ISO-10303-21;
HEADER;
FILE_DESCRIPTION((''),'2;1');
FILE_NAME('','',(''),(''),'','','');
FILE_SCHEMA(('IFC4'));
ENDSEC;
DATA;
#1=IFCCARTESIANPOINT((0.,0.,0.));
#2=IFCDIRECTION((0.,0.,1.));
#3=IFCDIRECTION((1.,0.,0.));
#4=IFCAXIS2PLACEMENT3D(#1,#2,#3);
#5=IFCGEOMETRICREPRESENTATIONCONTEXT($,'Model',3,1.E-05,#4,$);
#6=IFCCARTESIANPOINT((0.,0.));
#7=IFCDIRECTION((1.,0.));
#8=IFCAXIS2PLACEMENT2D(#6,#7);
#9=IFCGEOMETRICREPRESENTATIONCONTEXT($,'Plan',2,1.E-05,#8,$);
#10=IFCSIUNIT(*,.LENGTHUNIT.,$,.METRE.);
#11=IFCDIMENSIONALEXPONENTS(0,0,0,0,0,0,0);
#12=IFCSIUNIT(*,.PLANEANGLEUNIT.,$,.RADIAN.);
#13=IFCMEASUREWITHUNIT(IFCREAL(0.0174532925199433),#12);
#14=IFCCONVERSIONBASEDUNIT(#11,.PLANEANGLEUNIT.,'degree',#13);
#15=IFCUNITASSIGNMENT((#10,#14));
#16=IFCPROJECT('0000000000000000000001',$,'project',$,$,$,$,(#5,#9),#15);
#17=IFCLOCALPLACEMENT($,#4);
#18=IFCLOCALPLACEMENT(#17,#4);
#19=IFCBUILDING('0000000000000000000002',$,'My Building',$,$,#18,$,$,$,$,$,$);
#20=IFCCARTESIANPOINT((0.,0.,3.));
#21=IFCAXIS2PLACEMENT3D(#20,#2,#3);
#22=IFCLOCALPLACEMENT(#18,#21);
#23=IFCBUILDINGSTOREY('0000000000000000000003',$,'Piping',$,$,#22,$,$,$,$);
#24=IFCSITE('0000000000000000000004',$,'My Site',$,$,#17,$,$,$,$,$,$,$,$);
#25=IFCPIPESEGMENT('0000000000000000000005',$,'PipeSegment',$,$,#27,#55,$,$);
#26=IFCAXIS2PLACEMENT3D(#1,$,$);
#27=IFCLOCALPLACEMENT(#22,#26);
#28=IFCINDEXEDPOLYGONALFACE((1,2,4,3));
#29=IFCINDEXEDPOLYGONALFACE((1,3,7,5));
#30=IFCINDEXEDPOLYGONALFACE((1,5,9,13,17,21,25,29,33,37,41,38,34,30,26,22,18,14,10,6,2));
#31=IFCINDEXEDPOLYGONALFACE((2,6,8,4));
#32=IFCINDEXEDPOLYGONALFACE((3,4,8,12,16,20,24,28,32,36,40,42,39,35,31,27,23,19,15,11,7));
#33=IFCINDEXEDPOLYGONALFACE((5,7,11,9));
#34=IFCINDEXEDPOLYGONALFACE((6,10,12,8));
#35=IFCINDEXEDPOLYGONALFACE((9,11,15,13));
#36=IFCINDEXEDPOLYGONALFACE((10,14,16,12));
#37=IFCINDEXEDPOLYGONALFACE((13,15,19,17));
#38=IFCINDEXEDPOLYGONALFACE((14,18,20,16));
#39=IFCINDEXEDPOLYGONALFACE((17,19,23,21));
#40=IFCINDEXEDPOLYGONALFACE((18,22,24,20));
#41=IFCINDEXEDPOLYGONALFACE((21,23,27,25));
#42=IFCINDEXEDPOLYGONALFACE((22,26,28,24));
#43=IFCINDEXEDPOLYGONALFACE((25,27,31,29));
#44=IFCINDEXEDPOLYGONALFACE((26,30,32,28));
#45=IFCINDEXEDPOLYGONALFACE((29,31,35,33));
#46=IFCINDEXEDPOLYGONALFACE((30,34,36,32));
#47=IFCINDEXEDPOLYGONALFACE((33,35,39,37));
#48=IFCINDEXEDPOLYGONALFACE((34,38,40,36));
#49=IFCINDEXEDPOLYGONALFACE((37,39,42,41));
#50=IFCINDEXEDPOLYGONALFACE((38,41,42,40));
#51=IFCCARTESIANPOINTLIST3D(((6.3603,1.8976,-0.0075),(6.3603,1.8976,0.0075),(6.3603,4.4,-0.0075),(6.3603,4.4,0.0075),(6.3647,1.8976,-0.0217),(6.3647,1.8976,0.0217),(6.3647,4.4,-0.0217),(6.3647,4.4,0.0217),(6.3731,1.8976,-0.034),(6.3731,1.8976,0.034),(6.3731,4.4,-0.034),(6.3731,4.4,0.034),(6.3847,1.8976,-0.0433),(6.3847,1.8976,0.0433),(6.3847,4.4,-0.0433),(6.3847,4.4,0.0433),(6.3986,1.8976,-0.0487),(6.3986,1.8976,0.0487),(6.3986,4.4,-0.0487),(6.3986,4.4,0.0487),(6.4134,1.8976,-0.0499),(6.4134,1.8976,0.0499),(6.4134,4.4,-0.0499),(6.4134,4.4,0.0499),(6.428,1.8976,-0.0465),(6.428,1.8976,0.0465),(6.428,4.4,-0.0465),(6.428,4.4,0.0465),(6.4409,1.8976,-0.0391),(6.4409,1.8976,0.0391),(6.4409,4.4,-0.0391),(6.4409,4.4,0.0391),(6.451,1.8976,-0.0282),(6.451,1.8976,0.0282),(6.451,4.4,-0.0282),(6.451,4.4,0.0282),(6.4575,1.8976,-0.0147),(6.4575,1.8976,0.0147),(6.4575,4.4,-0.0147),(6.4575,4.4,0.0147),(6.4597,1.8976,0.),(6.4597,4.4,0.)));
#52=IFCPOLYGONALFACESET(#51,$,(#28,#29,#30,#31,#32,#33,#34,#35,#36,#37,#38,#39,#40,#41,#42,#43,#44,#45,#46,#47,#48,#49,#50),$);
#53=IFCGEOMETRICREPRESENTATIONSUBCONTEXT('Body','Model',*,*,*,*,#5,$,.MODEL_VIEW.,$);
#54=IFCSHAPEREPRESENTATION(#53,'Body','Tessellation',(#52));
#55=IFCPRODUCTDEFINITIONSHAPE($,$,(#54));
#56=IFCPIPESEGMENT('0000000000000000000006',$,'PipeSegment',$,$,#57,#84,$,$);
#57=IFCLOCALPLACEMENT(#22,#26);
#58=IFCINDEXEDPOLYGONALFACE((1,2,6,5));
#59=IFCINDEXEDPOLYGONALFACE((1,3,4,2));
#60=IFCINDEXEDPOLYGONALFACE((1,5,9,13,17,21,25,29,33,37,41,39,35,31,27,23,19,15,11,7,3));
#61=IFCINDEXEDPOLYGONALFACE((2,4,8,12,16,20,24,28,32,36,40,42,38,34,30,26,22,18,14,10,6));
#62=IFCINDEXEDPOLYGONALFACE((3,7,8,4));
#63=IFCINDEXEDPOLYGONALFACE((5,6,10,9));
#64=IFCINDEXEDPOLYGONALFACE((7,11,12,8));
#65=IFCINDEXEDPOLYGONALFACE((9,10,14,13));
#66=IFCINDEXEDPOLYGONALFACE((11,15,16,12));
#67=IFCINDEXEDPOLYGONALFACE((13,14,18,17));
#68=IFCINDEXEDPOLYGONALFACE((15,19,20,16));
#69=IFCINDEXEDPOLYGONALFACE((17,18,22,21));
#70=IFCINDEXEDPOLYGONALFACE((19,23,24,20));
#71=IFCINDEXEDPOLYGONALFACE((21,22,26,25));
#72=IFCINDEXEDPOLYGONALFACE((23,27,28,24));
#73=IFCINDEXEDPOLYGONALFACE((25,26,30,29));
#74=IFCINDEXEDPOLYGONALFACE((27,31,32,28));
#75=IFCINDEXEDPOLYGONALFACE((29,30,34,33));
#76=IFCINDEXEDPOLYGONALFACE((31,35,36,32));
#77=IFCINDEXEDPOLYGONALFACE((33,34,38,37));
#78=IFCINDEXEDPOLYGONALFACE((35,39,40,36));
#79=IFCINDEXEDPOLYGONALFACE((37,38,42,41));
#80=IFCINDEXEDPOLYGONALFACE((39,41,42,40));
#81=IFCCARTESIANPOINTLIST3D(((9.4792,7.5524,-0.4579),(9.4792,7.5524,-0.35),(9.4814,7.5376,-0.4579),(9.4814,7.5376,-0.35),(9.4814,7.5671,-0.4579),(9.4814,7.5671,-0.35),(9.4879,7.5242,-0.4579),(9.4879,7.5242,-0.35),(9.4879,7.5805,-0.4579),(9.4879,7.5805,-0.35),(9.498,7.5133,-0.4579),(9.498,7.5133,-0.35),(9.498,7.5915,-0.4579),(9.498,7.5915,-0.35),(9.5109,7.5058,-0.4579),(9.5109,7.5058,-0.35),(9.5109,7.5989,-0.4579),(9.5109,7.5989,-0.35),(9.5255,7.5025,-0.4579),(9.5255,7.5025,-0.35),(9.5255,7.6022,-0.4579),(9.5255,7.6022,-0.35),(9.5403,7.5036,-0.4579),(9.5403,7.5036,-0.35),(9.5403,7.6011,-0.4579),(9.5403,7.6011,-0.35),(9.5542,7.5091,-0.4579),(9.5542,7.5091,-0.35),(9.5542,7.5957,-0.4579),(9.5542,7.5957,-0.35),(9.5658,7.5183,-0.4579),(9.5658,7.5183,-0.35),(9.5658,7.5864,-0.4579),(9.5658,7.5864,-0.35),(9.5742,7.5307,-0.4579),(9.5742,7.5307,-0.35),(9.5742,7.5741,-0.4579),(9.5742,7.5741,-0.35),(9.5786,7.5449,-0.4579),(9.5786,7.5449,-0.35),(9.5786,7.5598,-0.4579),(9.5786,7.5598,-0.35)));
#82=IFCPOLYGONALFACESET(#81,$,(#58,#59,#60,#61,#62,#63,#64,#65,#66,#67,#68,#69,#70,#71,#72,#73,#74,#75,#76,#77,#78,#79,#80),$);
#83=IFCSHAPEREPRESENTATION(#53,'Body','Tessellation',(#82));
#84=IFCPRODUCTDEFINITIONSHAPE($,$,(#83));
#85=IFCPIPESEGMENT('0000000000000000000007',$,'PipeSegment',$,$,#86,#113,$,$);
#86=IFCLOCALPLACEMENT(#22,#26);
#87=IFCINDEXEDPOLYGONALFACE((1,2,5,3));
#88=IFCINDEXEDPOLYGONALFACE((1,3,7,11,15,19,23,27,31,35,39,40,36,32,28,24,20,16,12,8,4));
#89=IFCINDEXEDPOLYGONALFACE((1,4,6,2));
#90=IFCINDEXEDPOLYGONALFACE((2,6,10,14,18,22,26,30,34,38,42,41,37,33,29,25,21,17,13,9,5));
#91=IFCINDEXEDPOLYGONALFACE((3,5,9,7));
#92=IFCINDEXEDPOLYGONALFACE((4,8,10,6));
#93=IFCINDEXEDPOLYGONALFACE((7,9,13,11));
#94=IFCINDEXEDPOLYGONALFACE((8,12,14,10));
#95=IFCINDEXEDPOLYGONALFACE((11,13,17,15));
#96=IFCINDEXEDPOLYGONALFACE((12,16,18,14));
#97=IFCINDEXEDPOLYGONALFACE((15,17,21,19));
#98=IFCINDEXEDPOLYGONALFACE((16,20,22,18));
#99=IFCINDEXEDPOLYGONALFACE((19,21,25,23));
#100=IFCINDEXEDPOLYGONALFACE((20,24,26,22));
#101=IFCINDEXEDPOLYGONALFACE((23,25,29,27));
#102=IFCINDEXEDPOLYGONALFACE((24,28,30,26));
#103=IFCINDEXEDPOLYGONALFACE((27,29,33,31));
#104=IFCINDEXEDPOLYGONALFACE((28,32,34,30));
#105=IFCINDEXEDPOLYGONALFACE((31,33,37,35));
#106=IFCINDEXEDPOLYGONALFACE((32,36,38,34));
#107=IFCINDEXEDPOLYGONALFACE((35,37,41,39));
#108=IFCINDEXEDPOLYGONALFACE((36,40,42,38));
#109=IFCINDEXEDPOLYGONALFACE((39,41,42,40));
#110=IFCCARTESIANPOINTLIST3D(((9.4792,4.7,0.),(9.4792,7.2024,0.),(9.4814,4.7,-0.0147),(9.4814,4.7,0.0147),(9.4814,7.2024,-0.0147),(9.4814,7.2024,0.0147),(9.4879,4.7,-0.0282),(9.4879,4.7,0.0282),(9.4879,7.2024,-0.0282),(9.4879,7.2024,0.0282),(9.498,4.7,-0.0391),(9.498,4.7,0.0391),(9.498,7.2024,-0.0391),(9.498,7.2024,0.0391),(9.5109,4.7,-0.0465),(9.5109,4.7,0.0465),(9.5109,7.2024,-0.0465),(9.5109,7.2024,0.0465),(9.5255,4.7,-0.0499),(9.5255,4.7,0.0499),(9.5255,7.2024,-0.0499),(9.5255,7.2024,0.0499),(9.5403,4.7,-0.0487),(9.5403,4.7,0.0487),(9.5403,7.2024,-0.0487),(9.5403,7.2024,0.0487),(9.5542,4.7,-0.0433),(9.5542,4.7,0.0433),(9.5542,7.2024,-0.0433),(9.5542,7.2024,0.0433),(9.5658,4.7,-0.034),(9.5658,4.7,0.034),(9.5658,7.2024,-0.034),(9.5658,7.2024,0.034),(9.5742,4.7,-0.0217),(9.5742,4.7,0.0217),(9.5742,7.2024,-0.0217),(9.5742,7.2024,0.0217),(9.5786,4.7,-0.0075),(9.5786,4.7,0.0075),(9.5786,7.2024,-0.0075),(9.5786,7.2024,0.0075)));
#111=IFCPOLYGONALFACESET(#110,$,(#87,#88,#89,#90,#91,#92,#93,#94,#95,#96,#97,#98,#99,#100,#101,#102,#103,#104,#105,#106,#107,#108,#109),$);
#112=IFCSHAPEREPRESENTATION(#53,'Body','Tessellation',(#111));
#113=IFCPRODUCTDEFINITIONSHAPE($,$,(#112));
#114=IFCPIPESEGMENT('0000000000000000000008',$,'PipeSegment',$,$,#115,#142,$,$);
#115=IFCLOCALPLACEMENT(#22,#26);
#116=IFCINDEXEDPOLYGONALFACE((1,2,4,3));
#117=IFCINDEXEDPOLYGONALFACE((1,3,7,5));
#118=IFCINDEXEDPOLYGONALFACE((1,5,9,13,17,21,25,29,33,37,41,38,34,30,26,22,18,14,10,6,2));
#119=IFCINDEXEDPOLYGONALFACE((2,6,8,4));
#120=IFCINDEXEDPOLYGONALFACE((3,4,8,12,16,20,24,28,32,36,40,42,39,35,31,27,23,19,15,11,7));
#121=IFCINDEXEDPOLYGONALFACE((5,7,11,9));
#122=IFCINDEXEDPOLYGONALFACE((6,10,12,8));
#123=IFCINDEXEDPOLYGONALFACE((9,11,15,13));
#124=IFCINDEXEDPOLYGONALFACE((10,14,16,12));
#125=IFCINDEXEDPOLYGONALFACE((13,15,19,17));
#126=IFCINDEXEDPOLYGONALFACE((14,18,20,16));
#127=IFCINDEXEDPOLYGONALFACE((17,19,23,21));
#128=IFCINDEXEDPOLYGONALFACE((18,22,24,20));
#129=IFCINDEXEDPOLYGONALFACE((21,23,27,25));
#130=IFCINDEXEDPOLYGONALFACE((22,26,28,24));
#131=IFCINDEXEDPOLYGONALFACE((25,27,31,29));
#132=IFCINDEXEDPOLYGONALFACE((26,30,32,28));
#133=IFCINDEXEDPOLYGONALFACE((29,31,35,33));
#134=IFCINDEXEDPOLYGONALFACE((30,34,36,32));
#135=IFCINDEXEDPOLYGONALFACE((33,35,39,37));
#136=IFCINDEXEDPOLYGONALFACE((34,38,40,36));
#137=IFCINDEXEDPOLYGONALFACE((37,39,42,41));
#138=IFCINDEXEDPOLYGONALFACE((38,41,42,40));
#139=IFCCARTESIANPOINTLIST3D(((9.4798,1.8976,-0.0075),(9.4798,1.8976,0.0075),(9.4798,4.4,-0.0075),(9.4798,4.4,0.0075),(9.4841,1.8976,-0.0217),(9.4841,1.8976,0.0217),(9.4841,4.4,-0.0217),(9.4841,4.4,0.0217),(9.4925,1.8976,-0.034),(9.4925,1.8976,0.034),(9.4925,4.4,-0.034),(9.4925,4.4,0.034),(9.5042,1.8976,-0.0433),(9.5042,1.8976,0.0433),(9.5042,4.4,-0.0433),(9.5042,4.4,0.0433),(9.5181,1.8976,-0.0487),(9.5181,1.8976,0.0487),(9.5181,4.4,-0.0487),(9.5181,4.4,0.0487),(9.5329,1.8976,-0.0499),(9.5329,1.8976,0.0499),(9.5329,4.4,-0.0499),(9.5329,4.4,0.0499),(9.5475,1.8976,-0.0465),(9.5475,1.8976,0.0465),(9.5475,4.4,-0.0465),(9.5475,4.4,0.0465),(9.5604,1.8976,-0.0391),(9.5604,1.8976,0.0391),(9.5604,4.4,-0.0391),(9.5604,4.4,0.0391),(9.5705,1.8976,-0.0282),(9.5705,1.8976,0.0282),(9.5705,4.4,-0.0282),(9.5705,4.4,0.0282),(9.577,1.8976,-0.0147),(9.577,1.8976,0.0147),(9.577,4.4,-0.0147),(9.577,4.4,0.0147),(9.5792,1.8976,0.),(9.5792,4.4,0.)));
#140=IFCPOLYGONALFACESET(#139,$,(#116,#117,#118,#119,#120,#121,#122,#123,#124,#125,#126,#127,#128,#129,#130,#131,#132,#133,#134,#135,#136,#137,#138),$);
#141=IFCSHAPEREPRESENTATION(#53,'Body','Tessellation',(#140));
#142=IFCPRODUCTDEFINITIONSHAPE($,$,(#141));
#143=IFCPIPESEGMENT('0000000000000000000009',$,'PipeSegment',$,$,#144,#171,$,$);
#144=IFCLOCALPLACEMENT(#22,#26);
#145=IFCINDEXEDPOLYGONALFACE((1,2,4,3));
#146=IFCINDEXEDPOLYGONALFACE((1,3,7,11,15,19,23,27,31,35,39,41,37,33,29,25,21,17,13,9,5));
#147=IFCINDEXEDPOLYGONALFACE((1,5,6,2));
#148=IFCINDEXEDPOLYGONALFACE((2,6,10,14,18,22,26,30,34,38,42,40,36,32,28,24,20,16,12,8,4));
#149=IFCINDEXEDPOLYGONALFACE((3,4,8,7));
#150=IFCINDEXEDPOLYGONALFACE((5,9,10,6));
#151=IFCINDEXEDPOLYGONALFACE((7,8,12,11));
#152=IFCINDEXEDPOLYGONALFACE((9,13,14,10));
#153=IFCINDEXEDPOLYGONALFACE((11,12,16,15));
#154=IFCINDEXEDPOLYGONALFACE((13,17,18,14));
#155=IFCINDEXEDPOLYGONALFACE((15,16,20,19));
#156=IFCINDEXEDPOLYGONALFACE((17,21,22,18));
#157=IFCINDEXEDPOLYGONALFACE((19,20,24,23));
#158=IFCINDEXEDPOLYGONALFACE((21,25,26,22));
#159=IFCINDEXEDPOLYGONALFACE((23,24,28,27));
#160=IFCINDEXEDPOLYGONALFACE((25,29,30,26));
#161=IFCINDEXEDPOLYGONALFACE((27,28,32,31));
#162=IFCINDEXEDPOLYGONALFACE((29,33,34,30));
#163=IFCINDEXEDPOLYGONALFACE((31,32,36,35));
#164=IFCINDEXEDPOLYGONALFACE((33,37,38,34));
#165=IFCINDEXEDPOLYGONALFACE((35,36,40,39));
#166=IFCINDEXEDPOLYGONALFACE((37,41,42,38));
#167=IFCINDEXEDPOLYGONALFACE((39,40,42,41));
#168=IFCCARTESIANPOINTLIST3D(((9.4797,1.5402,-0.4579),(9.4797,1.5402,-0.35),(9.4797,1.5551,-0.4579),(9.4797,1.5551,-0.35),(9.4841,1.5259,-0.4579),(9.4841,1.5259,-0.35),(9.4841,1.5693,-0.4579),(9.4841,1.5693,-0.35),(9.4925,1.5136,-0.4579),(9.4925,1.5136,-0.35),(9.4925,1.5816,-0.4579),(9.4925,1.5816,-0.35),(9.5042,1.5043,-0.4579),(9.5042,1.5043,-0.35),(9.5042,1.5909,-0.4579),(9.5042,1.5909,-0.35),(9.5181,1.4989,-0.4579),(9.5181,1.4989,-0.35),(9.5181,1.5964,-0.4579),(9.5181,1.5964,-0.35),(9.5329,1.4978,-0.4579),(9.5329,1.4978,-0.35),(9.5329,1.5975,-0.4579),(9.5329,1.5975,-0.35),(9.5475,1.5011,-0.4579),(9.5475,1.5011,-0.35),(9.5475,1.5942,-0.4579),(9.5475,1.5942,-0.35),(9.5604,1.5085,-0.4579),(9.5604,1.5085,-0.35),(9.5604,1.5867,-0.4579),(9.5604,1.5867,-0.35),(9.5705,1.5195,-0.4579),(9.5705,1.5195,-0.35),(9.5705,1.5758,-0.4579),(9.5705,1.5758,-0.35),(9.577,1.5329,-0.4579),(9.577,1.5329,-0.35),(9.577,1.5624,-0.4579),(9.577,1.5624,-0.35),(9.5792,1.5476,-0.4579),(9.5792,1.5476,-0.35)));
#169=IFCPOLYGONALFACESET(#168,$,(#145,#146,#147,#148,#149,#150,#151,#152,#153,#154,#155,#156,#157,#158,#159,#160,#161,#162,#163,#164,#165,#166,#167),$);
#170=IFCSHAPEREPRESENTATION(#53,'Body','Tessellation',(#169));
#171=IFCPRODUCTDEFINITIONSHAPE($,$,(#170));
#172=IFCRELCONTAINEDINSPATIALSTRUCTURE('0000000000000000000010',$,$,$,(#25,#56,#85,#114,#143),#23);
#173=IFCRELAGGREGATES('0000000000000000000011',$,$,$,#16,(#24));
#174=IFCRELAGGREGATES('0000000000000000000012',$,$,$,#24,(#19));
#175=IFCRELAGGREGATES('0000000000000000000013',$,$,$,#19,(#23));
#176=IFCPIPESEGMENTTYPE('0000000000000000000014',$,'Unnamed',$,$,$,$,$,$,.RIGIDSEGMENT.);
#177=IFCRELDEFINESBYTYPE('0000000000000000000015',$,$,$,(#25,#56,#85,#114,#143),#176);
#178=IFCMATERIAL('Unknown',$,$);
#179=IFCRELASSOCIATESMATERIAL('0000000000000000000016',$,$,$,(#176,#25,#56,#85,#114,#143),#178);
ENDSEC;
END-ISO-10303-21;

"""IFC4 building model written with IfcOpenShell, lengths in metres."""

from ifc_helpers import new_model, entity, si_unit, converted_unit, frame, origin_with_axes, origin_2d_with_axis, place, context, subcontext, project, spatial, circle, extrude, material, material_profile, profile_set, profile_usage, type_object, element, save


model = new_model("IFC4")

# Units and contexts
model_context = context("Model", 3, precision=1e-05, world=origin_with_axes())
plan_context = context("Plan", 2, precision=1e-05, world=origin_2d_with_axis())
body_context = subcontext(model_context, "Body", "Model", "MODEL_VIEW")
ifc_project = project(units=[si_unit("LENGTHUNIT", "METRE"), converted_unit("PLANEANGLEUNIT", "degree", entity("IfcReal", 0.0174532925199433), si_unit("PLANEANGLEUNIT", "RADIAN"), dimensions=[0, 0, 0, 0, 0, 0, 0])], contexts=[model_context, plan_context])

# Site, building, storey
site_placement = place(None, origin_with_axes())
site = spatial("IfcSite", under=ifc_project, at=site_placement, Name="My Site")
building_placement = place(site_placement, origin_with_axes())
building = spatial("IfcBuilding", under=site, at=building_placement, Name="My Building")
storey_placement = place(building_placement, frame((0.0, 0.0, 3.0), z_axis=(0.0, 0.0, 1.0), x_axis=(1.0, 0.0, 0.0)))
storey = spatial("IfcBuildingStorey", under=building, at=storey_placement, Name="Piping")

# Pipe segments
ifc_material = material(Name="Unknown")
ifc_material_profile_1 = material_profile(ifc_material, circle(Radius=0.05))
ifc_profile_set_1 = profile_set([ifc_material_profile_1])
pipe_segment_type = type_object("IfcPipeSegmentType", Name="Unnamed", PredefinedType="RIGIDSEGMENT", material=ifc_profile_set_1)
ifc_profile_usage_1 = profile_usage(ifc_profile_set_1, cardinal=5)
pipe_segment_1_placement = place(storey_placement, frame((6.4097, 4.4, 0.0), z_axis=(0.0, -1.0, 0.0), x_axis=(1.0, 0.0, 0.0)))
element("IfcPipeSegment", 1, at=pipe_segment_1_placement, inside=storey, type_object=pipe_segment_type, material=ifc_profile_usage_1, Name="PipeSegment", context=body_context, shape_type="SweptSolid", body=[
    extrude(circle(Radius=0.05), origin_with_axes(), (0.0, 0.0, 1.0), 2.5024),
])
ifc_profile_usage_2 = profile_usage(ifc_profile_set_1, cardinal=5)
pipe_segment_2_placement = place(storey_placement, frame((9.5292, 7.5524, -0.35), z_axis=(0.0, 0.0, -1.0), x_axis=(-1.0, 0.0, 0.0)))
element("IfcPipeSegment", 2, at=pipe_segment_2_placement, inside=storey, type_object=pipe_segment_type, material=ifc_profile_usage_2, Name="PipeSegment", context=body_context, shape_type="SweptSolid", body=[
    extrude(circle(Radius=0.05), origin_with_axes(), (0.0, 0.0, 1.0), 0.1079),
])
ifc_profile_usage_3 = profile_usage(ifc_profile_set_1, cardinal=5)
pipe_segment_3_placement = place(storey_placement, frame((9.5292, 4.7, 0.0), z_axis=(0.0, 1.0, 0.0), x_axis=(-1.0, 0.0, 0.0)))
element("IfcPipeSegment", 3, at=pipe_segment_3_placement, inside=storey, type_object=pipe_segment_type, material=ifc_profile_usage_3, Name="PipeSegment", context=body_context, shape_type="SweptSolid", body=[
    extrude(circle(Radius=0.05), origin_with_axes(), (0.0, 0.0, 1.0), 2.5024),
])
ifc_profile_usage_4 = profile_usage(ifc_profile_set_1, cardinal=5)
pipe_segment_4_placement = place(storey_placement, frame((9.5292, 4.4, 0.0), z_axis=(0.0, -1.0, 0.0), x_axis=(1.0, 0.0, 0.0)))
element("IfcPipeSegment", 4, at=pipe_segment_4_placement, inside=storey, type_object=pipe_segment_type, material=ifc_profile_usage_4, Name="PipeSegment", context=body_context, shape_type="SweptSolid", body=[
    extrude(circle(Radius=0.05), origin_with_axes(), (0.0, 0.0, 1.0), 2.5024),
])
ifc_profile_usage_5 = profile_usage(ifc_profile_set_1, cardinal=5)
pipe_segment_5_placement = place(storey_placement, frame((9.5292, 1.5476, -0.35), z_axis=(0.0, 0.0, -1.0), x_axis=(1.0, 0.0, 0.0)))
element("IfcPipeSegment", 5, at=pipe_segment_5_placement, inside=storey, type_object=pipe_segment_type, material=ifc_profile_usage_5, Name="PipeSegment", context=body_context, shape_type="SweptSolid", body=[
    extrude(circle(Radius=0.05), origin_with_axes(), (0.0, 0.0, 1.0), 0.1079),
])

save(model, "model.ifc")
